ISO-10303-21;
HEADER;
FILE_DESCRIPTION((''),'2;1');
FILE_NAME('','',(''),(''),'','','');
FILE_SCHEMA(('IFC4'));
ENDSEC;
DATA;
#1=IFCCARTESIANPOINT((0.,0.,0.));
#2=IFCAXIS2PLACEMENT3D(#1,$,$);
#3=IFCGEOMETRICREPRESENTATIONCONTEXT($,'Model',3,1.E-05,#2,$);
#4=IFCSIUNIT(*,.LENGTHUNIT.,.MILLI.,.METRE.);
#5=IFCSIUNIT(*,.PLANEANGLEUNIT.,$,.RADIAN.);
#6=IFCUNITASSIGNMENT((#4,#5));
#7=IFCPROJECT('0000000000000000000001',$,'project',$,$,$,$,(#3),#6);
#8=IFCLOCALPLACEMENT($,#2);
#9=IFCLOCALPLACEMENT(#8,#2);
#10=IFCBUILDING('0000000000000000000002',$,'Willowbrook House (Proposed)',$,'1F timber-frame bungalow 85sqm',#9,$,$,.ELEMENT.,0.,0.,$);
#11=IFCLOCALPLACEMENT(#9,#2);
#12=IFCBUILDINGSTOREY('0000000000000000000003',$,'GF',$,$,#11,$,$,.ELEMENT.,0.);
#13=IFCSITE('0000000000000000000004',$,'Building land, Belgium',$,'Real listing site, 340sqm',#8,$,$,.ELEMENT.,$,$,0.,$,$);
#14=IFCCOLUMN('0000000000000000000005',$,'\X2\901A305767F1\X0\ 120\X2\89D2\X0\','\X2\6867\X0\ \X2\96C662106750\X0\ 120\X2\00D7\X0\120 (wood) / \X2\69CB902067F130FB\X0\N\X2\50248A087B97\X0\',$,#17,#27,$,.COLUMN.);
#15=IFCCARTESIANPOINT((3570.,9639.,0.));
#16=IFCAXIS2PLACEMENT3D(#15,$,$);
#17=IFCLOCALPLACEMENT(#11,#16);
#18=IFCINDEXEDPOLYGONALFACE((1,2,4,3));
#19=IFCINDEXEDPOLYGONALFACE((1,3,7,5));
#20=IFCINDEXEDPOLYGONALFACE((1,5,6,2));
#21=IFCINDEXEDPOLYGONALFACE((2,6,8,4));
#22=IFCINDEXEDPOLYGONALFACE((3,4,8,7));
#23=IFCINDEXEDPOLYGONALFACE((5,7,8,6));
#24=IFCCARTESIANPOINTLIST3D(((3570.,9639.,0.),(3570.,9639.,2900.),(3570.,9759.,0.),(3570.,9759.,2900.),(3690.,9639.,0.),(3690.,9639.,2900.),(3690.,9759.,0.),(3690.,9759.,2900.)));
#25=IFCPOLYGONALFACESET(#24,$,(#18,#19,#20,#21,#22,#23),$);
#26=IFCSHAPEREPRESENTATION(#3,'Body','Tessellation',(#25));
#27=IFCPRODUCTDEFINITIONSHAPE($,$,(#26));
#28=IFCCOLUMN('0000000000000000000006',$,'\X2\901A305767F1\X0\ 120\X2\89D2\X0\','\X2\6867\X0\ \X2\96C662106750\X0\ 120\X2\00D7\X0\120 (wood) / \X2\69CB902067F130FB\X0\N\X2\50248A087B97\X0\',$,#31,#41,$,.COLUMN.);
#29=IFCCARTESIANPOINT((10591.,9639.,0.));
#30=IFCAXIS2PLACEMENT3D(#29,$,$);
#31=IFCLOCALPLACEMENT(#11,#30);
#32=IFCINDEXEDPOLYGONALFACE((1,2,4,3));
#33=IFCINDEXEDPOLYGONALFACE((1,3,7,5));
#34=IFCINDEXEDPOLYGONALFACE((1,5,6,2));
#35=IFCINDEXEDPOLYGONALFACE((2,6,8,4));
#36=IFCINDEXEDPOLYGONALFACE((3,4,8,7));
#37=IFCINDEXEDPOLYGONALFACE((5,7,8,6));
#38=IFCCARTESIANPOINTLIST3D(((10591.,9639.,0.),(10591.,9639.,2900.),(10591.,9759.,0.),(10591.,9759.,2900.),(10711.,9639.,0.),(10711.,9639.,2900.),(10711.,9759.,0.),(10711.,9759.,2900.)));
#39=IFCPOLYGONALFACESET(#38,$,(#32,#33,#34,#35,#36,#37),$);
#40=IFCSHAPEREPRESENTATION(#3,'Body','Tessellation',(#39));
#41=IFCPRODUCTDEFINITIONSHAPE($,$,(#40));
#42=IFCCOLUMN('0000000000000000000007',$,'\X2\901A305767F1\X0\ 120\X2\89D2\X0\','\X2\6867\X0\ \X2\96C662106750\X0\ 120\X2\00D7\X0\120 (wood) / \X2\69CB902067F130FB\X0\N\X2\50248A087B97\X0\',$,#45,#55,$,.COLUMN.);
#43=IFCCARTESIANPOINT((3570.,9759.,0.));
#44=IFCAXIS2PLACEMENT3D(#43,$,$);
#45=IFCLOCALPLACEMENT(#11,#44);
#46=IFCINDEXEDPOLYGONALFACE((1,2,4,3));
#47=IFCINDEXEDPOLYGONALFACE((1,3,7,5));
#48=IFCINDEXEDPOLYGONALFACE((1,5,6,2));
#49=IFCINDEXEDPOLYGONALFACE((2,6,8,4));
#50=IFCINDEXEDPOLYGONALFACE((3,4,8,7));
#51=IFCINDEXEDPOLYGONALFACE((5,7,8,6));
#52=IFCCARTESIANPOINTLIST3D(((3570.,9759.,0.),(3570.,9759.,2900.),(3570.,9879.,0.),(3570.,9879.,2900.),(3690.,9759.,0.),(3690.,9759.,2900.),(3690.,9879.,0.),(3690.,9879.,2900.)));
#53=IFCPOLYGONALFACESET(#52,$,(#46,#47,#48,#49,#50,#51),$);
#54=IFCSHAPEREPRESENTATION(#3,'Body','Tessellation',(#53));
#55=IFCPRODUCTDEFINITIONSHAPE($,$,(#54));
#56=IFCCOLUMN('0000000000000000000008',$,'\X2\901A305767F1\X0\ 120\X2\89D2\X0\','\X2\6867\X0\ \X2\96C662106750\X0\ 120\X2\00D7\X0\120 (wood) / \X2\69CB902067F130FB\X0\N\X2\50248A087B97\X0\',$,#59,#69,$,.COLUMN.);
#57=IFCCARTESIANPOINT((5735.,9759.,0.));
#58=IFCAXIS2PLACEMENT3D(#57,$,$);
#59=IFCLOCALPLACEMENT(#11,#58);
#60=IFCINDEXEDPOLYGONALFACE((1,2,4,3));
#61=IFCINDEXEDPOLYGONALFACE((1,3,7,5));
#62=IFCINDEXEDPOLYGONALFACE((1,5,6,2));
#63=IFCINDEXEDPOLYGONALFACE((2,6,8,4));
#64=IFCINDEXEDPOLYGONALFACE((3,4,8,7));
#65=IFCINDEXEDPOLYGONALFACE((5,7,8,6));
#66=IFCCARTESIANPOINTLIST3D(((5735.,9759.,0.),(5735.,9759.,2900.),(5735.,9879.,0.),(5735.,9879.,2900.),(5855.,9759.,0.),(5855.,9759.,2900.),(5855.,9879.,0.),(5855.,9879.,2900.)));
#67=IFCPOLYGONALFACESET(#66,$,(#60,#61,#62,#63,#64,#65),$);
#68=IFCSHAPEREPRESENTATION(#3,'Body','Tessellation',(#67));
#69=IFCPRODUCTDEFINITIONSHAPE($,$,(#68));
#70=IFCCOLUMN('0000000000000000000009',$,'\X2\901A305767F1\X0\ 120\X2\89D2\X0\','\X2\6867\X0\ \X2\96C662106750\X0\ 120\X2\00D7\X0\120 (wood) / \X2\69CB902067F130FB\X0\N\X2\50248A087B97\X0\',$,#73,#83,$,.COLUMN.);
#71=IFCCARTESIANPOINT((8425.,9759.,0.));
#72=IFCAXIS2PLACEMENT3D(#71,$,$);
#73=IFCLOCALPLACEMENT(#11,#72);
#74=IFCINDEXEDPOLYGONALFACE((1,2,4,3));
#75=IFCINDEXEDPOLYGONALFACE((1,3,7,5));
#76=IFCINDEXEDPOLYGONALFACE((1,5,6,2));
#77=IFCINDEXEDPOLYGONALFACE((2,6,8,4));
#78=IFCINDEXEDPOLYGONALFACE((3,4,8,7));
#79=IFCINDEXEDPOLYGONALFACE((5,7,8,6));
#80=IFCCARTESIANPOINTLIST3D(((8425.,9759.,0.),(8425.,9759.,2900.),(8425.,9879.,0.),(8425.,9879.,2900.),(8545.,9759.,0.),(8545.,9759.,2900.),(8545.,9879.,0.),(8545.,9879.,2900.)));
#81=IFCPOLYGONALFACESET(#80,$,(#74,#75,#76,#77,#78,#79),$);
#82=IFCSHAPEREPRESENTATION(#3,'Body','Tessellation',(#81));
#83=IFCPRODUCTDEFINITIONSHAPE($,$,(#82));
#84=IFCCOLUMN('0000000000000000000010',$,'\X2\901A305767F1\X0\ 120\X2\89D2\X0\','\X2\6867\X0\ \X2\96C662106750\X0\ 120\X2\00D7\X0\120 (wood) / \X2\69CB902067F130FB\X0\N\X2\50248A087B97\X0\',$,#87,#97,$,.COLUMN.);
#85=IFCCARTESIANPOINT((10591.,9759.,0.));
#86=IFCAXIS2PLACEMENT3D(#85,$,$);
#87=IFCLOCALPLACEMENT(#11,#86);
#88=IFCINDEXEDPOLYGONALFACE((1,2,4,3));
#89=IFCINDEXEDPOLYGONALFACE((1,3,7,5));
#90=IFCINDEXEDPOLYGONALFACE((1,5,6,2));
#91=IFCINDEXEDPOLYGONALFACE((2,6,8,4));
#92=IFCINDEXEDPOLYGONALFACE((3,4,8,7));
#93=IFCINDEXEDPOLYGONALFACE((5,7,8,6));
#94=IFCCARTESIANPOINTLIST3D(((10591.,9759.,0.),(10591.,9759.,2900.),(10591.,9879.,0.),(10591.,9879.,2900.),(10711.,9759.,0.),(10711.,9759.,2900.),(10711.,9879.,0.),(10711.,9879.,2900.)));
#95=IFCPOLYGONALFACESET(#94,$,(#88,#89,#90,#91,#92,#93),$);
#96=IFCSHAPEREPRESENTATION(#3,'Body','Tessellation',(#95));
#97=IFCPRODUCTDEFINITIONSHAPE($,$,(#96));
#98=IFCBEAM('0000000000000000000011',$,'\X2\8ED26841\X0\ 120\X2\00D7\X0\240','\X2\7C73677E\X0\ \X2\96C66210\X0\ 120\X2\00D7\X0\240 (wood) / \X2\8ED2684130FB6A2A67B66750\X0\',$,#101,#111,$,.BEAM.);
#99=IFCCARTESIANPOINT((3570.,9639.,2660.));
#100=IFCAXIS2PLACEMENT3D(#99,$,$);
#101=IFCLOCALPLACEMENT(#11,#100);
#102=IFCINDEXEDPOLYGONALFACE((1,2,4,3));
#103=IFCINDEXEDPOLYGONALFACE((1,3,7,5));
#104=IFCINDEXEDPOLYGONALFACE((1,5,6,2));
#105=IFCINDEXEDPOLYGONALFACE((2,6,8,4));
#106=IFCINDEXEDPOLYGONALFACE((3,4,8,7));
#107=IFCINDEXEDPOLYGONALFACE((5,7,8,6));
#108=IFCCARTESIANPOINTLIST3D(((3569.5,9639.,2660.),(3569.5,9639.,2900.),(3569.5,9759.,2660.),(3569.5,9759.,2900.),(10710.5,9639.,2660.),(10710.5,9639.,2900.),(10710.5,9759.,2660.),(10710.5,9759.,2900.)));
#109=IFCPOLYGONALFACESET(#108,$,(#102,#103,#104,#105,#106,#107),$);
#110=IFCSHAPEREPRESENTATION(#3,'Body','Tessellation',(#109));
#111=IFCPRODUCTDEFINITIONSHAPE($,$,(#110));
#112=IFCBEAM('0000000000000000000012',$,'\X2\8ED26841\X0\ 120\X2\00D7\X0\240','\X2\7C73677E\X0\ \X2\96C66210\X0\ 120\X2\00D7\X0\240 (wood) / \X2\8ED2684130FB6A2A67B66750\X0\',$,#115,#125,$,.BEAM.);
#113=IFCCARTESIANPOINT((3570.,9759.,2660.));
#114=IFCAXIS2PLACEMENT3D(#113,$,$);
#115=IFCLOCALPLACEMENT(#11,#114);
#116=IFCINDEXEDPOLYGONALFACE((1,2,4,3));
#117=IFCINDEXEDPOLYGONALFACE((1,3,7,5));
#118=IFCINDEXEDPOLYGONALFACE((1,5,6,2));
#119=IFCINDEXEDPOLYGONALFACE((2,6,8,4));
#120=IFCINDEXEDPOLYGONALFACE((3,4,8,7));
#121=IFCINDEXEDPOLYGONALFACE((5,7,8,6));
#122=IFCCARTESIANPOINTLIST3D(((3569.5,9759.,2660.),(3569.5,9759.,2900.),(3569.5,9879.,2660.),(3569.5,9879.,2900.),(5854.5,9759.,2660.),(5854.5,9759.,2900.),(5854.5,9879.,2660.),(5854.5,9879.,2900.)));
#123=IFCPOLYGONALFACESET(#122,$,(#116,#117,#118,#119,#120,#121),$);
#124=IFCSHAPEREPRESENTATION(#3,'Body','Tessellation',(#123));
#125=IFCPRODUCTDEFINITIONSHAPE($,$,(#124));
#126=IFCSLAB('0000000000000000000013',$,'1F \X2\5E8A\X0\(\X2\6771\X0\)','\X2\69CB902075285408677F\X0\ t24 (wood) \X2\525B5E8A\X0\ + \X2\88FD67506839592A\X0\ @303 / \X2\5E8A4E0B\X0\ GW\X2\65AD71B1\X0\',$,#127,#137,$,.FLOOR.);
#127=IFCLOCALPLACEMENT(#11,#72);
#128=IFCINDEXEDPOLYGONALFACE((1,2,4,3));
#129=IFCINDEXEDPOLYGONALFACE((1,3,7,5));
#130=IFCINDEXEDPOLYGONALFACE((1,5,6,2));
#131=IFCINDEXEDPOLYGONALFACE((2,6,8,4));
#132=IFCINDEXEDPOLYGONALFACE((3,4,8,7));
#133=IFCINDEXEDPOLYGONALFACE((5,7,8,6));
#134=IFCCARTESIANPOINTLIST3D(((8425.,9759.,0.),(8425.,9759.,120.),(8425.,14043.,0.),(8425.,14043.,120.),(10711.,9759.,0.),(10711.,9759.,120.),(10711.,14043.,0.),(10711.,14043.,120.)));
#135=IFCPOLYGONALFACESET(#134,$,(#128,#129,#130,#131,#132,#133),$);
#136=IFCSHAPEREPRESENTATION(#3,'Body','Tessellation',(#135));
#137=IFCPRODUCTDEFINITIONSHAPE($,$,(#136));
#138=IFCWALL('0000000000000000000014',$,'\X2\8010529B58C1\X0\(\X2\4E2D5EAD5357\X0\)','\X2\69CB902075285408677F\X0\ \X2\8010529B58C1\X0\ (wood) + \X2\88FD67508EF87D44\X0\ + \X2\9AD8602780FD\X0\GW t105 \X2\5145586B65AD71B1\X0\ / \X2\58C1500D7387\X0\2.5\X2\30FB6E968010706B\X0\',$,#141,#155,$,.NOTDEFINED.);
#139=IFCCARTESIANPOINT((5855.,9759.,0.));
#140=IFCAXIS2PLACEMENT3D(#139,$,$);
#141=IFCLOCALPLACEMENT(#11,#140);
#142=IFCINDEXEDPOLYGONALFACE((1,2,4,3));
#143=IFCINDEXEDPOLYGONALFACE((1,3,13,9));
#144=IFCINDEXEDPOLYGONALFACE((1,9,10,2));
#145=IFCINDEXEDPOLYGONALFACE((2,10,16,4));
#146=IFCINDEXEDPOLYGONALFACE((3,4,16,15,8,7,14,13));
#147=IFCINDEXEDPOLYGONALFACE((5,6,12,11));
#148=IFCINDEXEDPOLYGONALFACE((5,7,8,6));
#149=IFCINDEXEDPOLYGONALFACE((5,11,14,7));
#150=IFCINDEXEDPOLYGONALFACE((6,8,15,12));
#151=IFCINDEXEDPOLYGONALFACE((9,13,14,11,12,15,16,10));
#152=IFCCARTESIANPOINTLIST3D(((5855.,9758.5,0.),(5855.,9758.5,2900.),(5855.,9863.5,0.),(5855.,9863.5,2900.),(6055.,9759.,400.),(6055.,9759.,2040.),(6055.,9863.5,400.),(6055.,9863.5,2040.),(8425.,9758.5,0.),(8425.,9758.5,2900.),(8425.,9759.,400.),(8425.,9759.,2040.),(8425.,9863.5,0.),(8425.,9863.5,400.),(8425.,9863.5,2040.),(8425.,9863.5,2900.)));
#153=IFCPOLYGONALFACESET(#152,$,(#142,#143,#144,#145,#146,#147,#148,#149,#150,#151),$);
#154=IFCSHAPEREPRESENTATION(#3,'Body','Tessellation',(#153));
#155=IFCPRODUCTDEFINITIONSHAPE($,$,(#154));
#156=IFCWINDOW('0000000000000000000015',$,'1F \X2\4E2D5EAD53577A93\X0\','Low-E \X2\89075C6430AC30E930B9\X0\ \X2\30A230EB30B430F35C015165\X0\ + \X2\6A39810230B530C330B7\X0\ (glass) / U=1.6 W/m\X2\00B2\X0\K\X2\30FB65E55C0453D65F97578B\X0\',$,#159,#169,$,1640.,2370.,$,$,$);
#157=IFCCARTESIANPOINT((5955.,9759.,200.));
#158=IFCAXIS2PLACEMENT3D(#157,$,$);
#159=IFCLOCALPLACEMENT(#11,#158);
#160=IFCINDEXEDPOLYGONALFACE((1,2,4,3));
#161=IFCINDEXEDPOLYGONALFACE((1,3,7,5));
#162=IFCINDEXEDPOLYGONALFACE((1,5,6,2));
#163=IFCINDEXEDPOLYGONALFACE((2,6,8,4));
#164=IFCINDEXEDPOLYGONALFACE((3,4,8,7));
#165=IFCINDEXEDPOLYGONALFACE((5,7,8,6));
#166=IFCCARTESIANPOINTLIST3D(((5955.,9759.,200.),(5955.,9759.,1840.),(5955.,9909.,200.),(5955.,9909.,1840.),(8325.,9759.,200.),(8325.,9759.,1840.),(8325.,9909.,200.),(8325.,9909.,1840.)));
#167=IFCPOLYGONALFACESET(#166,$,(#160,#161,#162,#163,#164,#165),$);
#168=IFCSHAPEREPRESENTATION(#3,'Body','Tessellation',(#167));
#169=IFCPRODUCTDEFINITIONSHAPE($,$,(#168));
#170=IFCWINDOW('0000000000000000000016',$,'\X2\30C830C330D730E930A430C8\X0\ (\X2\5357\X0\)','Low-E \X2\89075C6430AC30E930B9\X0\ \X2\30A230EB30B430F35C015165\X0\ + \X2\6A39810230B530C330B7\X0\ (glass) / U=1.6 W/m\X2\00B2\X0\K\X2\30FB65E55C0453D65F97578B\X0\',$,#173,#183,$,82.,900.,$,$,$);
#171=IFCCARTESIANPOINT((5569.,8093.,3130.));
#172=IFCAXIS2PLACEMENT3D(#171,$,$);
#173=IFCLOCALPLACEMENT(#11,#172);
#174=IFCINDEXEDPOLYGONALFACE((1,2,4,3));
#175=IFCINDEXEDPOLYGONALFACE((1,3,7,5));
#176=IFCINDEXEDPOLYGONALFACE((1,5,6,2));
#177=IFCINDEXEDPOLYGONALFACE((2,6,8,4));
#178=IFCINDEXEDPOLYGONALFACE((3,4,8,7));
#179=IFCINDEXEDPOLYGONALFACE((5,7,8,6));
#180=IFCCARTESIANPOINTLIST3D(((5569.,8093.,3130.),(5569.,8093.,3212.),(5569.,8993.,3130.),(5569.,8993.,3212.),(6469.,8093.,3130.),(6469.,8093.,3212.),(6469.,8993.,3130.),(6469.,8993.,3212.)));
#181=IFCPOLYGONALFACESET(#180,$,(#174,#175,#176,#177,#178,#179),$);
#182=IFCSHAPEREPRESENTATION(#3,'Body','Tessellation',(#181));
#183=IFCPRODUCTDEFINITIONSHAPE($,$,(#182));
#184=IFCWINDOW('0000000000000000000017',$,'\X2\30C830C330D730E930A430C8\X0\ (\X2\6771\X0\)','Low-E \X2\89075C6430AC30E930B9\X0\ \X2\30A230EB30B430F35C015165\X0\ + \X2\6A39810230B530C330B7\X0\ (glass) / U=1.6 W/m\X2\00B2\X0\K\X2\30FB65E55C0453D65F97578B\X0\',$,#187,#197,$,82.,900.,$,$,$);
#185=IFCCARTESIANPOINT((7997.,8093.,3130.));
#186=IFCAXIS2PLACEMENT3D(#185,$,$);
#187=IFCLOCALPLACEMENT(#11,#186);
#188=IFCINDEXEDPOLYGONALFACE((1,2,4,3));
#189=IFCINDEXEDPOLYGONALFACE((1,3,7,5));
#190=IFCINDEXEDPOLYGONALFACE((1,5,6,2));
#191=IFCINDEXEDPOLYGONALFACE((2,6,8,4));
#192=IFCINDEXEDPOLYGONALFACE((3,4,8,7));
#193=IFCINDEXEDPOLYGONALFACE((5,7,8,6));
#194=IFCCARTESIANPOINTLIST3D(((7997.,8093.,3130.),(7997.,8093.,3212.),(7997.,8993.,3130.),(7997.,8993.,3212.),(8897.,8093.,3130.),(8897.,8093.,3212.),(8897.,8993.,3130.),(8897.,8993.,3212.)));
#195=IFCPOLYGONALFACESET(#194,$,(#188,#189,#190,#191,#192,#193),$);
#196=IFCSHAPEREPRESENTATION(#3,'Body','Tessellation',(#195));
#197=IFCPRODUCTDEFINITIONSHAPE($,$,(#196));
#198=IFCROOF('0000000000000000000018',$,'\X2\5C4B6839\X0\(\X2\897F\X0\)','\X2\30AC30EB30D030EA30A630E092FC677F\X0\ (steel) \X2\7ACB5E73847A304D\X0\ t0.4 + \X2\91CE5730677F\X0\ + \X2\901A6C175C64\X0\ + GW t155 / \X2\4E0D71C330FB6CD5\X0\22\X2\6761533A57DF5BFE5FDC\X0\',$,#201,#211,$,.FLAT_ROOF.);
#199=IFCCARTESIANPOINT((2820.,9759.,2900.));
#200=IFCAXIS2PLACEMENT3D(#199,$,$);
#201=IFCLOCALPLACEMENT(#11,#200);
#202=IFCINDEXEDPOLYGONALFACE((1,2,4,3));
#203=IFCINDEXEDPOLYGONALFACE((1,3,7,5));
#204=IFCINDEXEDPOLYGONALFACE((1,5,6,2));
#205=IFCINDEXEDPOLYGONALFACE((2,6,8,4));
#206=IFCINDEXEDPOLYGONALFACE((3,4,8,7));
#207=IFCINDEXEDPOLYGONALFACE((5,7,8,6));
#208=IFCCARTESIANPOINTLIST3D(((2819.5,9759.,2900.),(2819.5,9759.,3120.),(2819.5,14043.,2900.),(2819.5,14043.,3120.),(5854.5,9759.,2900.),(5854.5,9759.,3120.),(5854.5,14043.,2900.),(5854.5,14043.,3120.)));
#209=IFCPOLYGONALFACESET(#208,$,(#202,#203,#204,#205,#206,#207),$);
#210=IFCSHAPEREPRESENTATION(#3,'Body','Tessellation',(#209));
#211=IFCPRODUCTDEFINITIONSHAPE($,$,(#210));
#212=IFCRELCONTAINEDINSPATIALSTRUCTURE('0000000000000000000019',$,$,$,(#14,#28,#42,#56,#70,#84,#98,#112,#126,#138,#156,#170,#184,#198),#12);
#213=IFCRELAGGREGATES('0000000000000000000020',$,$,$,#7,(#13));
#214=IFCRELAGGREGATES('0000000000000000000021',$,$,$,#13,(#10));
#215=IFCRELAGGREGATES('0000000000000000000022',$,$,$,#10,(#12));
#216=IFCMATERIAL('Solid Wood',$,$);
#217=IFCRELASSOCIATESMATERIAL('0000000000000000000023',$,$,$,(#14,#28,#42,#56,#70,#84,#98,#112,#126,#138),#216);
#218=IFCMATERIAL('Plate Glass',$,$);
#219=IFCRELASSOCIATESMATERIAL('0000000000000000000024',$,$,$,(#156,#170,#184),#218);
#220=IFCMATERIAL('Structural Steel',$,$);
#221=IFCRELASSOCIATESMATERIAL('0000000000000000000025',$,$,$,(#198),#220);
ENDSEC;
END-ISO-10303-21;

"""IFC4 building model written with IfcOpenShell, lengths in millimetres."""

from ifc_helpers import new_model, si_unit, frame, frame_2d, origin, place, context, project, spatial, rectangle, extrude, material, element, fill, save


model = new_model("IFC4")

# Units and contexts
model_context = context("Model", 3, precision=1e-05, world=origin())
ifc_project = project(units=[si_unit("LENGTHUNIT", "METRE", prefix="MILLI"), si_unit("PLANEANGLEUNIT", "RADIAN")], contexts=[model_context])

# Site, building, storey
site_placement = place(None, origin())
site = spatial("IfcSite", under=ifc_project, at=site_placement, Name="Building land, Belgium", ObjectType="Real listing site, 340sqm", CompositionType="ELEMENT", RefElevation=0.0)
building_placement = place(site_placement, origin())
building = spatial("IfcBuilding", under=site, at=building_placement, Name="Willowbrook House (Proposed)", ObjectType="1F timber-frame bungalow 85sqm", CompositionType="ELEMENT", ElevationOfRefHeight=0.0, ElevationOfTerrain=0.0)
storey_placement = place(building_placement, origin())
storey = spatial("IfcBuildingStorey", under=building, at=storey_placement, Name="GF", CompositionType="ELEMENT", Elevation=0.0)

# Columns
ifc_material_1 = material(Name="Solid Wood")
column_1_placement = place(storey_placement, frame((3570.0, 9639.0, 0.0)))
element("IfcColumn", 1, at=column_1_placement, inside=storey, material=ifc_material_1, Name="通し柱 120角", Description="桧 集成材 120×120 (wood) / 構造柱・N値計算", PredefinedType="COLUMN", context=model_context, shape_type="SweptSolid", body=[
    extrude(rectangle(XDim=120.0, YDim=120.0, at=frame_2d((60.0, 60.0))), frame((3570.0, 9639.0, 0.0)), (0.0, 0.0, 1.0), 2900.0),
])
column_2_placement = place(storey_placement, frame((10591.0, 9639.0, 0.0)))
element("IfcColumn", 2, at=column_2_placement, inside=storey, material=ifc_material_1, Name="通し柱 120角", Description="桧 集成材 120×120 (wood) / 構造柱・N値計算", PredefinedType="COLUMN", context=model_context, shape_type="SweptSolid", body=[
    extrude(rectangle(XDim=120.0, YDim=120.0, at=frame_2d((60.0, 60.0))), frame((10591.0, 9639.0, 0.0)), (0.0, 0.0, 1.0), 2900.0),
])
column_3_placement = place(storey_placement, frame((3570.0, 9759.0, 0.0)))
element("IfcColumn", 3, at=column_3_placement, inside=storey, material=ifc_material_1, Name="通し柱 120角", Description="桧 集成材 120×120 (wood) / 構造柱・N値計算", PredefinedType="COLUMN", context=model_context, shape_type="SweptSolid", body=[
    extrude(rectangle(XDim=120.0, YDim=120.0, at=frame_2d((60.0, 60.0))), frame((3570.0, 9759.0, 0.0)), (0.0, 0.0, 1.0), 2900.0),
])
column_4_placement = place(storey_placement, frame((5735.0, 9759.0, 0.0)))
element("IfcColumn", 4, at=column_4_placement, inside=storey, material=ifc_material_1, Name="通し柱 120角", Description="桧 集成材 120×120 (wood) / 構造柱・N値計算", PredefinedType="COLUMN", context=model_context, shape_type="SweptSolid", body=[
    extrude(rectangle(XDim=120.0, YDim=120.0, at=frame_2d((60.0, 60.0))), frame((5735.0, 9759.0, 0.0)), (0.0, 0.0, 1.0), 2900.0),
])
column_5_placement = place(storey_placement, frame((8425.0, 9759.0, 0.0)))
element("IfcColumn", 5, at=column_5_placement, inside=storey, material=ifc_material_1, Name="通し柱 120角", Description="桧 集成材 120×120 (wood) / 構造柱・N値計算", PredefinedType="COLUMN", context=model_context, shape_type="SweptSolid", body=[
    extrude(rectangle(XDim=120.0, YDim=120.0, at=frame_2d((60.0, 60.0))), frame((8425.0, 9759.0, 0.0)), (0.0, 0.0, 1.0), 2900.0),
])
column_6_placement = place(storey_placement, frame((10591.0, 9759.0, 0.0)))
element("IfcColumn", 6, at=column_6_placement, inside=storey, material=ifc_material_1, Name="通し柱 120角", Description="桧 集成材 120×120 (wood) / 構造柱・N値計算", PredefinedType="COLUMN", context=model_context, shape_type="SweptSolid", body=[
    extrude(rectangle(XDim=120.0, YDim=120.0, at=frame_2d((60.0, 60.0))), frame((10591.0, 9759.0, 0.0)), (0.0, 0.0, 1.0), 2900.0),
])

# Beams
beam_1_placement = place(storey_placement, frame((3570.0, 9639.0, 2660.0)))
element("IfcBeam", 7, at=beam_1_placement, inside=storey, material=ifc_material_1, Name="軒桁 120×240", Description="米松 集成 120×240 (wood) / 軒桁・横架材", PredefinedType="BEAM", context=model_context, shape_type="SweptSolid", body=[
    extrude(rectangle(XDim=7141.0, YDim=120.0, at=frame_2d((3570.0, 60.0))), frame((3570.0, 9639.0, 2660.0)), (0.0, 0.0, 1.0), 240.0),
])
beam_2_placement = place(storey_placement, frame((3570.0, 9759.0, 2660.0)))
element("IfcBeam", 8, at=beam_2_placement, inside=storey, material=ifc_material_1, Name="軒桁 120×240", Description="米松 集成 120×240 (wood) / 軒桁・横架材", PredefinedType="BEAM", context=model_context, shape_type="SweptSolid", body=[
    extrude(rectangle(XDim=2285.0, YDim=120.0, at=frame_2d((1142.0, 60.0))), frame((3570.0, 9759.0, 2660.0)), (0.0, 0.0, 1.0), 240.0),
])

# Slab
slab_1_placement = place(storey_placement, frame((8425.0, 9759.0, 0.0)))
element("IfcSlab", 9, at=slab_1_placement, inside=storey, material=ifc_material_1, Name="1F 床(東)", Description="構造用合板 t24 (wood) 剛床 + 製材根太 @303 / 床下 GW断熱", PredefinedType="FLOOR", context=model_context, shape_type="SweptSolid", body=[
    extrude(rectangle(XDim=2286.0, YDim=4284.0, at=frame_2d((1143.0, 2142.0))), frame((8425.0, 9759.0, 0.0)), (0.0, 0.0, 1.0), 120.0),
])

# Wall, opening, window
wall_1_placement = place(storey_placement, frame((5855.0, 9759.0, 0.0)))
wall_1 = element("IfcWall", 10, at=wall_1_placement, inside=storey, material=ifc_material_1, Name="耐力壁(中庭南)", Description="構造用合板 耐力壁 (wood) + 製材軸組 + 高性能GW t105 充填断熱 / 壁倍率2.5・準耐火", PredefinedType="NOTDEFINED", context=model_context, shape_type="SweptSolid", body=[
    extrude(rectangle(XDim=2570.0, YDim=105.0, at=frame_2d((1285.0, 52.0))), frame((5855.0, 9759.0, 0.0)), (0.0, 0.0, 1.0), 2900.0),
])
opening_placement = place(storey_placement, frame((5955.0, 9759.0, 200.0)))
opening = element("IfcOpeningElement", 11, at=opening_placement, cuts=wall_1, PredefinedType="NOTDEFINED", context=model_context, shape_type="SweptSolid", body=[
    extrude(rectangle(XDim=2370.0, YDim=150.0, at=frame_2d((1185.0, 75.0))), frame((5955.0, 9759.0, 200.0)), (0.0, 0.0, 1.0), 1640.0),
])
ifc_material_2 = material(Name="Plate Glass")
window_1_placement = place(storey_placement, frame((5955.0, 9759.0, 200.0)))
window_1 = element("IfcWindow", 12, at=window_1_placement, inside=storey, material=ifc_material_2, Name="1F 中庭南窓", Description="Low-E 複層ガラス アルゴン封入 + 樹脂サッシ (glass) / U=1.6 W/m²K・日射取得型", OverallHeight=1640.0, OverallWidth=2370.0, context=model_context, shape_type="SweptSolid", body=[
    extrude(rectangle(XDim=2370.0, YDim=150.0, at=frame_2d((1185.0, 75.0))), frame((5955.0, 9759.0, 200.0)), (0.0, 0.0, 1.0), 1640.0),
])
fill(opening, window_1)

# Windows
window_2_placement = place(storey_placement, frame((5569.0, 8093.0, 3130.0)))
element("IfcWindow", 13, at=window_2_placement, inside=storey, material=ifc_material_2, Name="トップライト (南)", Description="Low-E 複層ガラス アルゴン封入 + 樹脂サッシ (glass) / U=1.6 W/m²K・日射取得型", OverallHeight=82.0, OverallWidth=900.0, context=model_context, shape_type="SweptSolid", body=[
    extrude(rectangle(XDim=900.0, YDim=900.0, at=frame_2d((450.0, 450.0))), frame((5569.0, 8093.0, 3130.0)), (0.0, 0.0, 1.0), 82.0),
])
window_3_placement = place(storey_placement, frame((7997.0, 8093.0, 3130.0)))
element("IfcWindow", 14, at=window_3_placement, inside=storey, material=ifc_material_2, Name="トップライト (東)", Description="Low-E 複層ガラス アルゴン封入 + 樹脂サッシ (glass) / U=1.6 W/m²K・日射取得型", OverallHeight=82.0, OverallWidth=900.0, context=model_context, shape_type="SweptSolid", body=[
    extrude(rectangle(XDim=900.0, YDim=900.0, at=frame_2d((450.0, 450.0))), frame((7997.0, 8093.0, 3130.0)), (0.0, 0.0, 1.0), 82.0),
])

# Roof
ifc_material_3 = material(Name="Structural Steel")
roof_1_placement = place(storey_placement, frame((2820.0, 9759.0, 2900.0)))
element("IfcRoof", 15, at=roof_1_placement, inside=storey, material=ifc_material_3, Name="屋根(西)", Description="ガルバリウム鋼板 (steel) 立平葺き t0.4 + 野地板 + 通気層 + GW t155 / 不燃・法22条区域対応", PredefinedType="FLAT_ROOF", context=model_context, shape_type="SweptSolid", body=[
    extrude(rectangle(XDim=3035.0, YDim=4284.0, at=frame_2d((1517.0, 2142.0))), frame((2820.0, 9759.0, 2900.0)), (0.0, 0.0, 1.0), 220.0),
])

save(model, "model.ifc")
